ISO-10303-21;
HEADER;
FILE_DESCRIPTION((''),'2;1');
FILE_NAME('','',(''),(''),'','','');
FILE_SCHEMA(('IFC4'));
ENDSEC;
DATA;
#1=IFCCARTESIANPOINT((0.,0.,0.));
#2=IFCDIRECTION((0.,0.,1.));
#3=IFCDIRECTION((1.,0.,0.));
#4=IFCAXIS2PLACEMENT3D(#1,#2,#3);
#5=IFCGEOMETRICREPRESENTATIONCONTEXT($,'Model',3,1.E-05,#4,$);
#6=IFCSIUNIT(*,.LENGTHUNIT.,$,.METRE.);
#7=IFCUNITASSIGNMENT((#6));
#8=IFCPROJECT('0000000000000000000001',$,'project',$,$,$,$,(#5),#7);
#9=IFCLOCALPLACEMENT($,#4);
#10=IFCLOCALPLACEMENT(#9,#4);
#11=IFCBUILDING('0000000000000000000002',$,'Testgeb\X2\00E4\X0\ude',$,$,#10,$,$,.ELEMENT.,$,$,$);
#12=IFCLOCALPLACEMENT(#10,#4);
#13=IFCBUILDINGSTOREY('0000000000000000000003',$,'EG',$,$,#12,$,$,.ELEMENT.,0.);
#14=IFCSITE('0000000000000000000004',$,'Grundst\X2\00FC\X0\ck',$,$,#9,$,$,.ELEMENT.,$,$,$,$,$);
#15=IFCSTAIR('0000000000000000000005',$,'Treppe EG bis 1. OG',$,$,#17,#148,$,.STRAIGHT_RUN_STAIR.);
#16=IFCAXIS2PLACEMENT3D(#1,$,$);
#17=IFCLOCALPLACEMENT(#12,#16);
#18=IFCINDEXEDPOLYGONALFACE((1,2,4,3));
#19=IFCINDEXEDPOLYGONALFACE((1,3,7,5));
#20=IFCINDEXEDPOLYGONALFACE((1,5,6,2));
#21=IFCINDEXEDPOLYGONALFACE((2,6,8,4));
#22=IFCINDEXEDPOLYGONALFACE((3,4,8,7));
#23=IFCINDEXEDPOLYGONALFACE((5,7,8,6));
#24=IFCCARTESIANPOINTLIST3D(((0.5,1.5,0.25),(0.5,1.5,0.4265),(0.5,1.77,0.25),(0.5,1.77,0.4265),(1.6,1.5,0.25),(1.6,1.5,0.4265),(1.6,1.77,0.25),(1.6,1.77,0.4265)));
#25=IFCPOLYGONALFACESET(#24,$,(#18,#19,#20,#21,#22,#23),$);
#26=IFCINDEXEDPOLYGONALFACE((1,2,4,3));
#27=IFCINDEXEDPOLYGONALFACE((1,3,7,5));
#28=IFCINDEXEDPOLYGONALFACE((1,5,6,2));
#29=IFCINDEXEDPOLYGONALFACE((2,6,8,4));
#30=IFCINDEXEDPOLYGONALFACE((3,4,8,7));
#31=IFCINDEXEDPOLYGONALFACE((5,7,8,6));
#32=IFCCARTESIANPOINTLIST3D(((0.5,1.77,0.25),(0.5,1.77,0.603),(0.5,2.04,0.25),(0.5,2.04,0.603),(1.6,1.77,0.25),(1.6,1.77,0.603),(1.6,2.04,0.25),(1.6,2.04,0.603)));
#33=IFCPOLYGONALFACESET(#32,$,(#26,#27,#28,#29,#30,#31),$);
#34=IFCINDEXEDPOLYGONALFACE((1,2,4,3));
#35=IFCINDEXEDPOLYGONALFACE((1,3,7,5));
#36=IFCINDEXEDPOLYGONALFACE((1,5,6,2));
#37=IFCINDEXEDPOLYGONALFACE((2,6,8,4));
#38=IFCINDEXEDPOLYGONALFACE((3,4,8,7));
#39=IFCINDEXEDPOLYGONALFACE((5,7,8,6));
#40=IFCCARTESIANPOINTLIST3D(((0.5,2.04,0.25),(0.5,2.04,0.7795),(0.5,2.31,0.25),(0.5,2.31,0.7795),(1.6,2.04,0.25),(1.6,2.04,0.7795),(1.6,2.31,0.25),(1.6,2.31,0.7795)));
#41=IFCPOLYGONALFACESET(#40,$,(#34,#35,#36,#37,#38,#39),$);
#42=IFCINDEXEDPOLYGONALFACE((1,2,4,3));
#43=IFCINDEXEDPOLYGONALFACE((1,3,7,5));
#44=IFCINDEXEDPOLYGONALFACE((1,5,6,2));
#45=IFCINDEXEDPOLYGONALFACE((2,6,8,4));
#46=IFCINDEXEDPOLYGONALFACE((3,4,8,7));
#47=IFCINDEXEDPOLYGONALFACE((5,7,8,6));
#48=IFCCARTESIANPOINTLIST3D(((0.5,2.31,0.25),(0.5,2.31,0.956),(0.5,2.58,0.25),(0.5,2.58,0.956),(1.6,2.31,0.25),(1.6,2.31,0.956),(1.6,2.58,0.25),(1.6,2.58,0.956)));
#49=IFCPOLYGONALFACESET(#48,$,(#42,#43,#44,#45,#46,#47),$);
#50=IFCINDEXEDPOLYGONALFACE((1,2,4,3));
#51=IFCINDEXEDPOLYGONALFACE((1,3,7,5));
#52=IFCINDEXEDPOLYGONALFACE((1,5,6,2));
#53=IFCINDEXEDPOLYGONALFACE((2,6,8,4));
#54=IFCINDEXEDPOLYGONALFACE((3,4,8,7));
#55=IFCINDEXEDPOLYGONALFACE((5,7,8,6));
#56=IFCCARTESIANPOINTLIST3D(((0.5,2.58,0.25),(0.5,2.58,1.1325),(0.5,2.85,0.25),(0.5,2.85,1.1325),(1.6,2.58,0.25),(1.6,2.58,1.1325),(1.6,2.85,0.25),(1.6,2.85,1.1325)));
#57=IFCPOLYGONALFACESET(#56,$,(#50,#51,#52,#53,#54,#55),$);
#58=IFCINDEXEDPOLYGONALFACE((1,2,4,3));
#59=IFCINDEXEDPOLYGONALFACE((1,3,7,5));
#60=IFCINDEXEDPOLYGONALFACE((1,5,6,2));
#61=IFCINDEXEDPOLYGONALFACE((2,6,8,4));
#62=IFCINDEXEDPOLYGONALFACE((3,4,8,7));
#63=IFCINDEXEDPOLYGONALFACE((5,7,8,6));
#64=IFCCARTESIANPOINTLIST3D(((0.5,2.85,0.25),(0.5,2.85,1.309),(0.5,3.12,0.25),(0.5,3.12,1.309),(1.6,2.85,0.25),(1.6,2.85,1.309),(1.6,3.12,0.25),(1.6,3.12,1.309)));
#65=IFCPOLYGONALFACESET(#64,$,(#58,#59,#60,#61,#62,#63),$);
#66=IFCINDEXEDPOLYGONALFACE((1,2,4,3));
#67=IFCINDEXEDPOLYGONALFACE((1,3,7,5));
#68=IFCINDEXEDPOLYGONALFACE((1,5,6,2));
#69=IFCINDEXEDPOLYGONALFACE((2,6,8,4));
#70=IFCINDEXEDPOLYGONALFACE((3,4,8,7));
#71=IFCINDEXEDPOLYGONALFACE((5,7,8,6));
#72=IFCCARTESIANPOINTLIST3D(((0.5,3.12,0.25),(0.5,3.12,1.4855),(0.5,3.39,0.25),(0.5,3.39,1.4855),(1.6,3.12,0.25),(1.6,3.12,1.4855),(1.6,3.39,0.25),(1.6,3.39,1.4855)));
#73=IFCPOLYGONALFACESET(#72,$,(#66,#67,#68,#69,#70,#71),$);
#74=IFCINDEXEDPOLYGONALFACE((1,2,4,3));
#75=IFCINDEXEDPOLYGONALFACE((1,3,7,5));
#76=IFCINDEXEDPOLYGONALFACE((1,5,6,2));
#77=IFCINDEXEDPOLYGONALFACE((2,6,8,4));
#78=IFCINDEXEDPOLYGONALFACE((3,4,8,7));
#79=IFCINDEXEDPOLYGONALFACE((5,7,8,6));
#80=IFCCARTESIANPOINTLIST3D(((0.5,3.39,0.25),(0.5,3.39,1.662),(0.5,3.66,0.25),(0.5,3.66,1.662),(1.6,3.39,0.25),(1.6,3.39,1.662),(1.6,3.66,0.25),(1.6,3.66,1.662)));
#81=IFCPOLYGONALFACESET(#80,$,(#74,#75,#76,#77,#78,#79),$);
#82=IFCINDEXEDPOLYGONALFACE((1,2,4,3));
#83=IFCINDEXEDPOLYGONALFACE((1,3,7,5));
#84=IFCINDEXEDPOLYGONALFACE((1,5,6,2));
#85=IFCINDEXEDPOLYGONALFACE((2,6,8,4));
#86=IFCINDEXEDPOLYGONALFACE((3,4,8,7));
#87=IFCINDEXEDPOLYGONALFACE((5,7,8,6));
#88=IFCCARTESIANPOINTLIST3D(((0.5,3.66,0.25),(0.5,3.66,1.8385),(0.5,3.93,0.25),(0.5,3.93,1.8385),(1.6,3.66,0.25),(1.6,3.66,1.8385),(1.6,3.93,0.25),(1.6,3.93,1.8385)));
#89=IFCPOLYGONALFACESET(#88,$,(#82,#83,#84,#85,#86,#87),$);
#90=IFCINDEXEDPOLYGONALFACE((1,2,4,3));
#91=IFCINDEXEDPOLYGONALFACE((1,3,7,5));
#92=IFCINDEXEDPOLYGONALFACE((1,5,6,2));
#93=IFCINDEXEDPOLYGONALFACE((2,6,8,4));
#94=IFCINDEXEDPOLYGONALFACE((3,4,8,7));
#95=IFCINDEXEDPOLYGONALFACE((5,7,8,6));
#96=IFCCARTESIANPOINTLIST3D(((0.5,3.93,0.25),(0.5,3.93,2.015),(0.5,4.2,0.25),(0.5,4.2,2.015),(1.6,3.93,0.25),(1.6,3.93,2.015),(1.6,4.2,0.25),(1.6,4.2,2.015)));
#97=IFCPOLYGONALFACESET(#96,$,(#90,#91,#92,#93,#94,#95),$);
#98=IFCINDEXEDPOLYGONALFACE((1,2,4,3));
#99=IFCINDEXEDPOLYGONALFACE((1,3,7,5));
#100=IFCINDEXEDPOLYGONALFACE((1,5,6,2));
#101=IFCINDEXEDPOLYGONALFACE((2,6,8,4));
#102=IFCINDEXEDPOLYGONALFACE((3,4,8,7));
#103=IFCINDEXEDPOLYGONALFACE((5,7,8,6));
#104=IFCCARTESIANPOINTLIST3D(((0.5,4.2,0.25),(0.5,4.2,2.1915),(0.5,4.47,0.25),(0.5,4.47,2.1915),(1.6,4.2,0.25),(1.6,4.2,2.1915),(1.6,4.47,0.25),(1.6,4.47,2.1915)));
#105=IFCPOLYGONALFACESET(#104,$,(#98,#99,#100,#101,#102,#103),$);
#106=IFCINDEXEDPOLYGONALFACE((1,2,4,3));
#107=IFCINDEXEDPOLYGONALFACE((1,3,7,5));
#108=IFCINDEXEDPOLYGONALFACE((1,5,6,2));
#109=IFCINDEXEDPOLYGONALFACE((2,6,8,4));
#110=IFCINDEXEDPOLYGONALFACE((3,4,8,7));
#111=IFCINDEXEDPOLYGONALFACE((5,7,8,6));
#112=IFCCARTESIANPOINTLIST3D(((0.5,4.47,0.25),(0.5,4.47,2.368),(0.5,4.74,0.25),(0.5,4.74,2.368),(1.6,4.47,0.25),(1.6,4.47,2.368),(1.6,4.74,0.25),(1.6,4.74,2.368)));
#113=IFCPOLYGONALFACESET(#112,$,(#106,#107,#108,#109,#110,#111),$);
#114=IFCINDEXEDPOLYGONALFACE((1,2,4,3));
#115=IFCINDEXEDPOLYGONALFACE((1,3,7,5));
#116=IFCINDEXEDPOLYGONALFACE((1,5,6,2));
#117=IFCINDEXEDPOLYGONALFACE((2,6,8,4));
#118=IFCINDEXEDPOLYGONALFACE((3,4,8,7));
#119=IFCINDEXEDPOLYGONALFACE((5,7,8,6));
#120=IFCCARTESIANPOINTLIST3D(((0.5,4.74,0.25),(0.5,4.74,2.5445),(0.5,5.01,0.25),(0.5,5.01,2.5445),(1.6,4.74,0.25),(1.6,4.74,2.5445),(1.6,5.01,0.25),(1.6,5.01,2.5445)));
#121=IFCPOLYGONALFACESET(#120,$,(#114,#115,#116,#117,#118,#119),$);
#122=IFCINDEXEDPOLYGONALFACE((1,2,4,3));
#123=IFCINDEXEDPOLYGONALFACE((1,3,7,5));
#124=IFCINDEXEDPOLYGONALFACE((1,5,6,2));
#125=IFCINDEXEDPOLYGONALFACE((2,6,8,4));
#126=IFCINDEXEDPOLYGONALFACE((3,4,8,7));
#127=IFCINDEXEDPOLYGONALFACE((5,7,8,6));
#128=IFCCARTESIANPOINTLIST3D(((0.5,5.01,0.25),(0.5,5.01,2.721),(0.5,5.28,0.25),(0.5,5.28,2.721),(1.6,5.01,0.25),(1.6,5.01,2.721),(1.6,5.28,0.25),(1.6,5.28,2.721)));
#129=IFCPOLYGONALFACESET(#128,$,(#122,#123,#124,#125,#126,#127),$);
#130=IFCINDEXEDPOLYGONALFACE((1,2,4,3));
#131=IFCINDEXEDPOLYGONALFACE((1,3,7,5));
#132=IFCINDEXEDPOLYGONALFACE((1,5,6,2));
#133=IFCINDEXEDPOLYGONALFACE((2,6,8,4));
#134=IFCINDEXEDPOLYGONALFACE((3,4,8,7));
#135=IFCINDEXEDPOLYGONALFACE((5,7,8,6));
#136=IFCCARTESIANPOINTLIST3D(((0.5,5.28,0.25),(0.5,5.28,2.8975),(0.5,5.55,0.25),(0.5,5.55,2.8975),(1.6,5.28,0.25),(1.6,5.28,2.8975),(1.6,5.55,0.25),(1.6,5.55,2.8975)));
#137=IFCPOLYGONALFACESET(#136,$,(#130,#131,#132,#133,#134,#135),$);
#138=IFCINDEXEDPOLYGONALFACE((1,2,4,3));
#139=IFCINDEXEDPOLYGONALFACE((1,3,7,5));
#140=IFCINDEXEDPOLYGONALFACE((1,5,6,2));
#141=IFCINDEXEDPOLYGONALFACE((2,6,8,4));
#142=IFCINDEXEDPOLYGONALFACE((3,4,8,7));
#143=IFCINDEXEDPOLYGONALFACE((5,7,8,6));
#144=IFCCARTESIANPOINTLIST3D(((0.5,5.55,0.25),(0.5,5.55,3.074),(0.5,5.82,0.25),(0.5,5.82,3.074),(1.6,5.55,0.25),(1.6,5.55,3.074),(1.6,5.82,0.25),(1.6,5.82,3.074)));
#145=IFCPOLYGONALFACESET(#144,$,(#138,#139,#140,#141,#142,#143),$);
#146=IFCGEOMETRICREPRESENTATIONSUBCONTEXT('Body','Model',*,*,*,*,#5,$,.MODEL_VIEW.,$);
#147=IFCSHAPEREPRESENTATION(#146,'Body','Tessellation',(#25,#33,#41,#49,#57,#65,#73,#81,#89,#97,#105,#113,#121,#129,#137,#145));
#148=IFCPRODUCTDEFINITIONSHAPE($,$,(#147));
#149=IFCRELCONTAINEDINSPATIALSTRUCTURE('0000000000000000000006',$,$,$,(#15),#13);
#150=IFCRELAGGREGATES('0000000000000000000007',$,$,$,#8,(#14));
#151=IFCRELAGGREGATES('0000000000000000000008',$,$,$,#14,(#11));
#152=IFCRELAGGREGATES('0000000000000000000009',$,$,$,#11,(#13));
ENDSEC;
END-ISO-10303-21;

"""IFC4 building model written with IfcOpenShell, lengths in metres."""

from ifc_helpers import new_model, si_unit, frame, frame_2d, origin_with_axes, place, context, subcontext, project, spatial, rectangle, extrude, element, save


model = new_model("IFC4")

# Units and contexts
model_context = context("Model", 3, precision=1e-05, world=origin_with_axes())
body_context = subcontext(model_context, "Body", "Model", "MODEL_VIEW")
ifc_project = project(units=[si_unit("LENGTHUNIT", "METRE")], contexts=[model_context])

# Site, building, storey
site_placement = place(None, origin_with_axes())
site = spatial("IfcSite", under=ifc_project, at=site_placement, Name="Grundstück", CompositionType="ELEMENT")
building_placement = place(site_placement, origin_with_axes())
building = spatial("IfcBuilding", under=site, at=building_placement, Name="Testgebäude", CompositionType="ELEMENT")
storey_placement = place(building_placement, origin_with_axes())
storey = spatial("IfcBuildingStorey", under=building, at=storey_placement, Name="EG", CompositionType="ELEMENT", Elevation=0.0)

# Stair
stair_placement = place(storey_placement, frame((0.5, 1.5, 0.25), z_axis=(0.0, 0.0, 1.0), x_axis=(1.0, 0.0, 0.0)))
element("IfcStair", 1, at=stair_placement, inside=storey, Name="Treppe EG bis 1. OG", PredefinedType="STRAIGHT_RUN_STAIR", context=body_context, shape_type="SweptSolid", body=[
    extrude(rectangle(XDim=1.1, YDim=0.27, at=frame_2d((0.55, 0.135))), origin_with_axes(), (0.0, 0.0, 1.0), 0.1765),
    extrude(rectangle(XDim=1.1, YDim=0.27, at=frame_2d((0.55, 0.405))), origin_with_axes(), (0.0, 0.0, 1.0), 0.353),
    extrude(rectangle(XDim=1.1, YDim=0.27, at=frame_2d((0.55, 0.675))), origin_with_axes(), (0.0, 0.0, 1.0), 0.5295),
    extrude(rectangle(XDim=1.1, YDim=0.27, at=frame_2d((0.55, 0.945))), origin_with_axes(), (0.0, 0.0, 1.0), 0.706),
    extrude(rectangle(XDim=1.1, YDim=0.27, at=frame_2d((0.55, 1.215))), origin_with_axes(), (0.0, 0.0, 1.0), 0.8825),
    extrude(rectangle(XDim=1.1, YDim=0.27, at=frame_2d((0.55, 1.485))), origin_with_axes(), (0.0, 0.0, 1.0), 1.059),
    extrude(rectangle(XDim=1.1, YDim=0.27, at=frame_2d((0.55, 1.755))), origin_with_axes(), (0.0, 0.0, 1.0), 1.2355),
    extrude(rectangle(XDim=1.1, YDim=0.27, at=frame_2d((0.55, 2.025))), origin_with_axes(), (0.0, 0.0, 1.0), 1.412),
    extrude(rectangle(XDim=1.1, YDim=0.27, at=frame_2d((0.55, 2.295))), origin_with_axes(), (0.0, 0.0, 1.0), 1.5885),
    extrude(rectangle(XDim=1.1, YDim=0.27, at=frame_2d((0.55, 2.565))), origin_with_axes(), (0.0, 0.0, 1.0), 1.765),
    extrude(rectangle(XDim=1.1, YDim=0.27, at=frame_2d((0.55, 2.835))), origin_with_axes(), (0.0, 0.0, 1.0), 1.9415),
    extrude(rectangle(XDim=1.1, YDim=0.27, at=frame_2d((0.55, 3.105))), origin_with_axes(), (0.0, 0.0, 1.0), 2.118),
    extrude(rectangle(XDim=1.1, YDim=0.27, at=frame_2d((0.55, 3.375))), origin_with_axes(), (0.0, 0.0, 1.0), 2.2945),
    extrude(rectangle(XDim=1.1, YDim=0.27, at=frame_2d((0.55, 3.645))), origin_with_axes(), (0.0, 0.0, 1.0), 2.471),
    extrude(rectangle(XDim=1.1, YDim=0.27, at=frame_2d((0.55, 3.915))), origin_with_axes(), (0.0, 0.0, 1.0), 2.6475),
    extrude(rectangle(XDim=1.1, YDim=0.27, at=frame_2d((0.55, 4.185))), origin_with_axes(), (0.0, 0.0, 1.0), 2.824),
])

save(model, "model.ifc")
